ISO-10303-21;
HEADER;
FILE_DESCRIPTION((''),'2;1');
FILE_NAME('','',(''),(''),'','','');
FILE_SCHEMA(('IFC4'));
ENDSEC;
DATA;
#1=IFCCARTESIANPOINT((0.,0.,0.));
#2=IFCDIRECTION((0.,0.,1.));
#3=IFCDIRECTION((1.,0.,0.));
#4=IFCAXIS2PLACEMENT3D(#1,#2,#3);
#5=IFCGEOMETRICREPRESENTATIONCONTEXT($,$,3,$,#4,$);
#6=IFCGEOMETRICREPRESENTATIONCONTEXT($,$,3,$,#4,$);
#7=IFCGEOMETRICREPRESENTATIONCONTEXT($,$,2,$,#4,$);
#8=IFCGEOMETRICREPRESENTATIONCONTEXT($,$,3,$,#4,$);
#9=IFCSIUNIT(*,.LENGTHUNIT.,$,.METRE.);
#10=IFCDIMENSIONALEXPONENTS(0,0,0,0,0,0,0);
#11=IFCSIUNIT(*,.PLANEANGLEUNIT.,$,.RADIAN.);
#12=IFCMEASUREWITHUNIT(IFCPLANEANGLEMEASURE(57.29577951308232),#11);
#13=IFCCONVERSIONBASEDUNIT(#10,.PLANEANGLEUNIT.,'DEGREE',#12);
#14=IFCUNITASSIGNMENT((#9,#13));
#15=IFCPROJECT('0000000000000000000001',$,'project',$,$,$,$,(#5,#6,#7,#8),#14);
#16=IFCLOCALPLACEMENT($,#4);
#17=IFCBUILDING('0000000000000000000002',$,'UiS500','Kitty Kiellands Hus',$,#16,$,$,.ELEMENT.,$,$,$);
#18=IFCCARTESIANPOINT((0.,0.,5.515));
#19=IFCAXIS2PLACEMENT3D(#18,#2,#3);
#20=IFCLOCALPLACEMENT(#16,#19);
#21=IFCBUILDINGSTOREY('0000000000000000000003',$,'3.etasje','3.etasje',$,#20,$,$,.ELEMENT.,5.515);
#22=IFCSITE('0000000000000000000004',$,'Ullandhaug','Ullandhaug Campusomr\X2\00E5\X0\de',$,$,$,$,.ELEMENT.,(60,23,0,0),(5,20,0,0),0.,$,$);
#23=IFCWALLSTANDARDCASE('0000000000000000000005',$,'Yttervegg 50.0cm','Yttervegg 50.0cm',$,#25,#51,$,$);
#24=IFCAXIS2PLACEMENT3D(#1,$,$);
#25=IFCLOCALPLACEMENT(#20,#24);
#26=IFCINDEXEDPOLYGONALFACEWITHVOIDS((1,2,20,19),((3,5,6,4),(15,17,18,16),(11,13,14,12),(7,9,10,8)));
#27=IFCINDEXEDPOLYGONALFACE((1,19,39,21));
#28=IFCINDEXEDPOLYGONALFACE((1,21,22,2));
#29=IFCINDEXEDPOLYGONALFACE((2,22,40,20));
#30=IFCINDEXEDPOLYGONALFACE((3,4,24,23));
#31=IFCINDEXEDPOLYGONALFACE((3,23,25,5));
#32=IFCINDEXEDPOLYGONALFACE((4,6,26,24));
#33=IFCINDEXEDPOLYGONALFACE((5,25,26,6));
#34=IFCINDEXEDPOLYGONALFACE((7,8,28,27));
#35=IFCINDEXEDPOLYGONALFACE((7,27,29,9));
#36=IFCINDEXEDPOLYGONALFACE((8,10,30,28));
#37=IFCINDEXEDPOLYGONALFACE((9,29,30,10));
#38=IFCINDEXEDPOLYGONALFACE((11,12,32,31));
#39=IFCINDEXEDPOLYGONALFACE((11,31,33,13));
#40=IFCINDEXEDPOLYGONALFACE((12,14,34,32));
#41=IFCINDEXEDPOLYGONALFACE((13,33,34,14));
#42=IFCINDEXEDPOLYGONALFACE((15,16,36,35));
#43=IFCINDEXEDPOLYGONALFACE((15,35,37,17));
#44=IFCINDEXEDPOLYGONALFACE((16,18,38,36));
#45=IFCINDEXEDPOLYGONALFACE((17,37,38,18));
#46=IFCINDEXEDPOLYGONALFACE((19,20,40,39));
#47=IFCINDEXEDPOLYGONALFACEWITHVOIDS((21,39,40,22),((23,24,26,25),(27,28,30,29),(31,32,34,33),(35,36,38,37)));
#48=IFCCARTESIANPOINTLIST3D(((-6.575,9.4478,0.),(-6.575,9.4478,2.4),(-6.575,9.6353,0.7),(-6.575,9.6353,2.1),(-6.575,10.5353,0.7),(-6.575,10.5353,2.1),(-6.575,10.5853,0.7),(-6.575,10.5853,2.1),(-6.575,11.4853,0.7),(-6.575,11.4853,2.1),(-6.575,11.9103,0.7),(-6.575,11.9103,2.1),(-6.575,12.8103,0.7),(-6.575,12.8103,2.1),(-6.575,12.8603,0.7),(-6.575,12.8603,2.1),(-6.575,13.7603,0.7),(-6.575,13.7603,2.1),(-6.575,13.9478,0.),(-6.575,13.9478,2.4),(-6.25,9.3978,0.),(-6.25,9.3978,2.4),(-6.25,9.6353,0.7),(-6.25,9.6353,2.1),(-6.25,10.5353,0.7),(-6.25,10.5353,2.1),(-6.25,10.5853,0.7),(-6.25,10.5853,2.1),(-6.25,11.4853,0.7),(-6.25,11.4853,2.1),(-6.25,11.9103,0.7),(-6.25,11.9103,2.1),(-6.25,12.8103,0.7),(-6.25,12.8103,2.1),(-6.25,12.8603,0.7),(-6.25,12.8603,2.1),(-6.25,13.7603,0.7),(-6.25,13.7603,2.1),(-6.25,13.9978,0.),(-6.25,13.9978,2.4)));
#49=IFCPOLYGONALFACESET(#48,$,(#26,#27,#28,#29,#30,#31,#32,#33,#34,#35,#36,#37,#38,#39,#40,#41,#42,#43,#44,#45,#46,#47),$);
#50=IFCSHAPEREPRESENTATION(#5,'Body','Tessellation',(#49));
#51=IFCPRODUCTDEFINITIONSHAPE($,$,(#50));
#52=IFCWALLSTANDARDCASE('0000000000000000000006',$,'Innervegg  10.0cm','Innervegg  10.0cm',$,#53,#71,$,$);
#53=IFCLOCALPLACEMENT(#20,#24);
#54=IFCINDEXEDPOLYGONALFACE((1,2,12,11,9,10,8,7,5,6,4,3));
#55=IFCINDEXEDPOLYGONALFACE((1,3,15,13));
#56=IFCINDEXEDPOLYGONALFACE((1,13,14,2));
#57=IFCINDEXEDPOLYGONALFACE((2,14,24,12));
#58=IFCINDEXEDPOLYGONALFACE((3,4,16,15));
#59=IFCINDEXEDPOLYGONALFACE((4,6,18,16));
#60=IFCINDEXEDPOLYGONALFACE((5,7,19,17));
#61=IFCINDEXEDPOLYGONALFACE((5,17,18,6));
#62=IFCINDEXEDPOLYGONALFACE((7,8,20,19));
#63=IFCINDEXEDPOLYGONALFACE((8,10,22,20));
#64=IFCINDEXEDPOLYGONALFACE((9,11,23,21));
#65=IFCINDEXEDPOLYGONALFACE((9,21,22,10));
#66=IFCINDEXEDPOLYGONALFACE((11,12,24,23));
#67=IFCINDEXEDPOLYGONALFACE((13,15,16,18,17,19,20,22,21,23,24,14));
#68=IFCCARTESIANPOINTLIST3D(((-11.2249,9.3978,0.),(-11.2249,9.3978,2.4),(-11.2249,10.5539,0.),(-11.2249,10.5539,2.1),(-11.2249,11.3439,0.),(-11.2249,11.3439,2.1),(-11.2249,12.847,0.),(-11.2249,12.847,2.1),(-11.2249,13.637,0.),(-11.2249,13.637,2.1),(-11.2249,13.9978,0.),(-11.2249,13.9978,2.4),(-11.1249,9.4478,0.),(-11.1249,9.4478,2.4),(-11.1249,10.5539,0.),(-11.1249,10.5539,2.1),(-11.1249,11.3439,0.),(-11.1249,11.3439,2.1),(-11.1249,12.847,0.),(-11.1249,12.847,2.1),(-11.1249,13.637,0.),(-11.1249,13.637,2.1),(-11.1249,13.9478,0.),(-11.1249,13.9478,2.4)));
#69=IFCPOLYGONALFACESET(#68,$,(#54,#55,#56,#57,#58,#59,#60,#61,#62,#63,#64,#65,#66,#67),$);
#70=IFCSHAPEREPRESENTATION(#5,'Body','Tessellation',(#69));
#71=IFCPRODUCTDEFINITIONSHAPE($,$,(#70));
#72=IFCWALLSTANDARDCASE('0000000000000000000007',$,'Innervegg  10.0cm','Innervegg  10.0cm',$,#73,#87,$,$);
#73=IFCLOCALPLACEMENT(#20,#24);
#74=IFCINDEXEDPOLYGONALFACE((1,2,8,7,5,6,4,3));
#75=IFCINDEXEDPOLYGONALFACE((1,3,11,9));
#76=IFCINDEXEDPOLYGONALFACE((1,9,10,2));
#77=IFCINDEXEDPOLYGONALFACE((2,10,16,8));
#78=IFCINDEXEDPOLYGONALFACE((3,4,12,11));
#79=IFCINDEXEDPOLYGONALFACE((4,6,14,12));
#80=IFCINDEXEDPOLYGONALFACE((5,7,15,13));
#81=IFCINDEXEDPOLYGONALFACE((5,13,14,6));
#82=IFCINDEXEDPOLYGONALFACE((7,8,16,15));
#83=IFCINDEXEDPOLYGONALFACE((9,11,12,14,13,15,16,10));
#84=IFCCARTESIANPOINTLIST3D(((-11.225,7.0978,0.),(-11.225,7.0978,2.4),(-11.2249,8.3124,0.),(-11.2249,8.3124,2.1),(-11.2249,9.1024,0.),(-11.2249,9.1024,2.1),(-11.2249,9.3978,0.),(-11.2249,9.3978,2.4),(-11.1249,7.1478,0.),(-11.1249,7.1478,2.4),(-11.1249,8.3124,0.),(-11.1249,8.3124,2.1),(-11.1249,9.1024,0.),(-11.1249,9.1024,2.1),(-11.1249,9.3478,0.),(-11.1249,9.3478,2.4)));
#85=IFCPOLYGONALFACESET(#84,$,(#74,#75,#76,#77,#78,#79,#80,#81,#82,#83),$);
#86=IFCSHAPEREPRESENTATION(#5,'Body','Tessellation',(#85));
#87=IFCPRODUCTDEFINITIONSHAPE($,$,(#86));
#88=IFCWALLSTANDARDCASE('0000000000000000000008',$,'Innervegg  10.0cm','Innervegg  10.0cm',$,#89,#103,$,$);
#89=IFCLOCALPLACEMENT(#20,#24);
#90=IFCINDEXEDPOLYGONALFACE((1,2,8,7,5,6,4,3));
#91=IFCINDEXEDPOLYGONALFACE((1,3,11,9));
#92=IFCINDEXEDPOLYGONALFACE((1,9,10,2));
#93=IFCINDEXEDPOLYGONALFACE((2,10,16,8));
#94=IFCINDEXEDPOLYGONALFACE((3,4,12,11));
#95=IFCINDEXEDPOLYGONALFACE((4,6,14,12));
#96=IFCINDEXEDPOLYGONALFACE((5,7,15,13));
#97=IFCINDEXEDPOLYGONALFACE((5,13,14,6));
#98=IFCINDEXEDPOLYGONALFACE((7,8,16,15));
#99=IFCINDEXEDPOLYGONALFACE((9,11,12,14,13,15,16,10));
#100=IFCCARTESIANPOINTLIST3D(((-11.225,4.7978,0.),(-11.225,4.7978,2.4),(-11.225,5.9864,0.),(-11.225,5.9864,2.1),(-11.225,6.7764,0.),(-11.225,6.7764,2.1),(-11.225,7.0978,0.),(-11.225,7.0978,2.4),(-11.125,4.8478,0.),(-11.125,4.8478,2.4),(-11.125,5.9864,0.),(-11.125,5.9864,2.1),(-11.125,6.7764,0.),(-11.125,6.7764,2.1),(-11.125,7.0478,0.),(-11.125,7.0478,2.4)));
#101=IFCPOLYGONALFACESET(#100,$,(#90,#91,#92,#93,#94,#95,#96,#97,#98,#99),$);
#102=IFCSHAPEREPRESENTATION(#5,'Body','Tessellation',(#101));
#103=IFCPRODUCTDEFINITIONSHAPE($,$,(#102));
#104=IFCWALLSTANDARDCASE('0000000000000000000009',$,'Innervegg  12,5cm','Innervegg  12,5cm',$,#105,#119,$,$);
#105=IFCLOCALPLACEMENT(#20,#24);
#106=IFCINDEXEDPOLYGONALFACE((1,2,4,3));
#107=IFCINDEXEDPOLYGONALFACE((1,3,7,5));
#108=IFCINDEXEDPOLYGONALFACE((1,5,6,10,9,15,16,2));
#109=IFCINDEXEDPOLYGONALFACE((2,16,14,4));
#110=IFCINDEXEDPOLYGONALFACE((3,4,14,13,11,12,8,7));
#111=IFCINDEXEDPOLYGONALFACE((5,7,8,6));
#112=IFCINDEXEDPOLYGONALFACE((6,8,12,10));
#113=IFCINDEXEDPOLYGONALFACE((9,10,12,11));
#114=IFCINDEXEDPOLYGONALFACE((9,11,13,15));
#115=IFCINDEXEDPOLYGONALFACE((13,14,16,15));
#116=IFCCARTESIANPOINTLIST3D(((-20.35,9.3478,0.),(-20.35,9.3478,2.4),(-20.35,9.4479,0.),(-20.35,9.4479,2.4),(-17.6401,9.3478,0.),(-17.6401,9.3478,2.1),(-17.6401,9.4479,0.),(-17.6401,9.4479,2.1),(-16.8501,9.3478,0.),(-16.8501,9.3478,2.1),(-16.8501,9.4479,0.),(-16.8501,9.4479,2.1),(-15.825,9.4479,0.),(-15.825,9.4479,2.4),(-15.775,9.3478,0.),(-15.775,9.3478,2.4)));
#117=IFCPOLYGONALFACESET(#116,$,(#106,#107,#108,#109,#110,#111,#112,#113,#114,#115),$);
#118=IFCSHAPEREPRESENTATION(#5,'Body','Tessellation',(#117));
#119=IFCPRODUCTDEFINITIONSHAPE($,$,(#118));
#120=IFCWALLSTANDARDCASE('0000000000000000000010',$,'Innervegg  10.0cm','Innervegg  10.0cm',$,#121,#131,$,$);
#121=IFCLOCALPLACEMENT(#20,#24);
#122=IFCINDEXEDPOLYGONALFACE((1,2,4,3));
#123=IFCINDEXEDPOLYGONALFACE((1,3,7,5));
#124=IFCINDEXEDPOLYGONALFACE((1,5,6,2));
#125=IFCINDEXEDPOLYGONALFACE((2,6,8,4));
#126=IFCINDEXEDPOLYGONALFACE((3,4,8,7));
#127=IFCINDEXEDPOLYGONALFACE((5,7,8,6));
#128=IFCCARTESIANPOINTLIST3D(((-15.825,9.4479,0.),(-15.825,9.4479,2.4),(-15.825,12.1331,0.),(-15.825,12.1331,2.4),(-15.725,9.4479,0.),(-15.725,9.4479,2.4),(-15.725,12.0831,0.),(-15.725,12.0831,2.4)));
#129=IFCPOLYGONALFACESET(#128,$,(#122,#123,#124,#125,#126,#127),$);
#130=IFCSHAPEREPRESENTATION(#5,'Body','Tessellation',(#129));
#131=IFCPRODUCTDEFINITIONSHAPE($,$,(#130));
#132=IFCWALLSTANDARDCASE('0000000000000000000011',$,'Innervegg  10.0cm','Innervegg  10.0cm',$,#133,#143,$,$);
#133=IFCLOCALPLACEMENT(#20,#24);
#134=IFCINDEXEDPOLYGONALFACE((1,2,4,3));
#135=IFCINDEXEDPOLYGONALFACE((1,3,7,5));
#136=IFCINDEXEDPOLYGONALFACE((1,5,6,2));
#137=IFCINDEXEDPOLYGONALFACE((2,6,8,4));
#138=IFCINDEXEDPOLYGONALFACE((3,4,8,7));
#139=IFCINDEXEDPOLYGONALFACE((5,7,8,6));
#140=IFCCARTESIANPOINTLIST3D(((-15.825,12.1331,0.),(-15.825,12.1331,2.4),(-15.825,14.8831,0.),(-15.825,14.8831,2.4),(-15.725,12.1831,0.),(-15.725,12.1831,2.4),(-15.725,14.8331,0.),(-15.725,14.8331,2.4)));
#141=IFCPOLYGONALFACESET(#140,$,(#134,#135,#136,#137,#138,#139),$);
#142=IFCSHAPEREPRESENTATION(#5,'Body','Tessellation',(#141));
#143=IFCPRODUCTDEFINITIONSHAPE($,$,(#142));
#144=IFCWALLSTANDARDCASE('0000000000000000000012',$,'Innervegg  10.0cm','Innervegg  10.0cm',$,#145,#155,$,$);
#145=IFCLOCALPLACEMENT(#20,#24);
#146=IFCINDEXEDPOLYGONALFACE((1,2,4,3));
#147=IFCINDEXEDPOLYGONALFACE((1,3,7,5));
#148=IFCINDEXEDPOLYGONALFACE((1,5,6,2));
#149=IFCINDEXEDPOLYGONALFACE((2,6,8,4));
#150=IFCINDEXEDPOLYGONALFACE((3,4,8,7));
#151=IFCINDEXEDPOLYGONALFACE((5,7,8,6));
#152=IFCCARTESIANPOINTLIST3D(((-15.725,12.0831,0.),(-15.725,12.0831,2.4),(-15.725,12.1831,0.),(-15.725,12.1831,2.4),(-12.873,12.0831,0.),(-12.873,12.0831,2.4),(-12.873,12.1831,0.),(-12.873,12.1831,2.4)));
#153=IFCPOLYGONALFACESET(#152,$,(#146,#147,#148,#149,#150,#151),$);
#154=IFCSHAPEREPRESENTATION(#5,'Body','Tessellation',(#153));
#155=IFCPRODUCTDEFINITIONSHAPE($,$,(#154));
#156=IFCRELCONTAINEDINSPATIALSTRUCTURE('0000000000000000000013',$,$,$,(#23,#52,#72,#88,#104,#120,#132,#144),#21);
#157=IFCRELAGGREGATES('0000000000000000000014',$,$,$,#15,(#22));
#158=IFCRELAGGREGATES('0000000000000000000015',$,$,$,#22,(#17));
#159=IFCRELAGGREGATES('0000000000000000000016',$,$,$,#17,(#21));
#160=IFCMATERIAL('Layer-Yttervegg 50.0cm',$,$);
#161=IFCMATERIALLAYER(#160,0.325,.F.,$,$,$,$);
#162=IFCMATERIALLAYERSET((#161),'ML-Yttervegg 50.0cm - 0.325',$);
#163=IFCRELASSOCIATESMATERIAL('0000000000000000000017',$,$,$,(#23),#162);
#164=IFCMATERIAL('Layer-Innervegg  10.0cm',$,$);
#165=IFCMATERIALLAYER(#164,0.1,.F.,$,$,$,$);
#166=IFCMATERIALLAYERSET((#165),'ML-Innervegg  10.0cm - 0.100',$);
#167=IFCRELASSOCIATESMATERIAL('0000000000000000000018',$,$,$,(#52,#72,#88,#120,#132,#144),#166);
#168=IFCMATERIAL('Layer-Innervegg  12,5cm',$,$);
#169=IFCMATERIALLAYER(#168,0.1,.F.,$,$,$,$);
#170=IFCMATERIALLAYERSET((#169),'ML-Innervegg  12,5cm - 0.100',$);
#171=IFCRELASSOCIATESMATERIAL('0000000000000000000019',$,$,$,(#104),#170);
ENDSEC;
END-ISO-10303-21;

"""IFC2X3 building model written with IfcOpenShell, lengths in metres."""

from ifc_helpers import new_model, entity, si_unit, converted_unit, frame, origin_with_axes, place, context, project, spatial, polyline, outline, extrude, material, layer, layer_set, layer_usage, element, save


model = new_model("IFC2X3")

# Units and contexts
context_of_model_1 = context(None, 3, world=origin_with_axes())
context_of_model_2 = context(None, 3, world=origin_with_axes())
context_of_model_3 = context(None, 2, world=origin_with_axes())
context_of_model_4 = context(None, 3, world=origin_with_axes())
ifc_project = project(units=[si_unit("LENGTHUNIT", "METRE"), converted_unit("PLANEANGLEUNIT", "DEGREE", entity("IfcPlaneAngleMeasure", 57.29577951308232), si_unit("PLANEANGLEUNIT", "RADIAN"), dimensions=[0, 0, 0, 0, 0, 0, 0])], contexts=[context_of_model_1, context_of_model_2, context_of_model_3, context_of_model_4])

# Site, building, storey
site = spatial("IfcSite", under=ifc_project, Name="Ullandhaug", Description="Ullandhaug Campusområde", CompositionType="ELEMENT", RefLatitude=(60, 23, 0, 0), RefLongitude=(5, 20, 0, 0), RefElevation=0.0)
building_placement = place(None, origin_with_axes())
building = spatial("IfcBuilding", under=site, at=building_placement, Name="UiS500", Description="Kitty Kiellands Hus", CompositionType="ELEMENT")
storey_placement = place(building_placement, frame((0.0, 0.0, 5.515), z_axis=(0.0, 0.0, 1.0), x_axis=(1.0, 0.0, 0.0)))
storey = spatial("IfcBuildingStorey", under=building, at=storey_placement, Name="3.etasje", Description="3.etasje", CompositionType="ELEMENT", Elevation=5.515)

# Shared definitions
ifc_material_1 = material(Name="Layer-Innervegg  10.0cm")
ifc_layer_1 = layer(ifc_material_1, 0.1, ventilated=False)
ifc_layer_set_1 = layer_set([ifc_layer_1], Name="ML-Innervegg  10.0cm - 0.100")
ifc_layer_usage_1 = layer_usage(ifc_layer_set_1, "AXIS2", "POSITIVE", 0.0)

# Shared definitions
ifc_material_2 = material(Name="Layer-Yttervegg 50.0cm")
ifc_layer_2 = layer(ifc_material_2, 0.325, ventilated=False)
ifc_layer_set_2 = layer_set([ifc_layer_2], Name="ML-Yttervegg 50.0cm - 0.325")
ifc_layer_usage_2 = layer_usage(ifc_layer_set_2, "AXIS2", "POSITIVE", 0.0)

# Walls, openings
wall_1_placement = place(storey_placement, frame((-6.25, 9.3978, 0.0), z_axis=(0.0, 0.0, 1.0), x_axis=(0.0, 1.0, 0.0)))
wall_1 = element("IfcWallStandardCase", 1, at=wall_1_placement, inside=storey, material=ifc_layer_usage_2, Name="Yttervegg 50.0cm", Description="Yttervegg 50.0cm", context=context_of_model_1, shape_type="SweptSolid", body=[
    extrude(outline(polyline([(0.0, 0.0), (4.6, 0.0), (4.55, 0.325), (0.05, 0.325), (0.0, 0.0)])), frame((0.0, 0.0, 0.0), z_axis=(0.0, 0.0, 1.0), x_axis=(1.0, 0.0, 0.0)), (0.0, 0.0, 1.0), 2.4),
])
opening_1_placement = place(wall_1_placement, frame((0.2375, 0.325, 0.7), z_axis=(0.0, 0.0, 1.0), x_axis=(1.0, 0.0, 0.0)))
element("IfcOpeningElement", 2, at=opening_1_placement, cuts=wall_1, context=context_of_model_1, shape_type="SweptSolid", body=[
    extrude(outline(polyline([(0.0, 0.0), (1.4, 0.0), (1.4, 0.9), (0.0, 0.9), (0.0, 0.0)])), frame((0.0, 0.0, 0.0), z_axis=(0.0, 1.0, 0.0), x_axis=(0.0, 0.0, 1.0)), (0.0, 0.0, -1.0), 0.325),
])
opening_2_placement = place(wall_1_placement, frame((1.1875, 0.325, 0.7), z_axis=(0.0, 0.0, 1.0), x_axis=(1.0, 0.0, 0.0)))
element("IfcOpeningElement", 3, at=opening_2_placement, cuts=wall_1, context=context_of_model_1, shape_type="SweptSolid", body=[
    extrude(outline(polyline([(0.0, 0.0), (1.4, 0.0), (1.4, 0.9), (0.0, 0.9), (0.0, 0.0)])), frame((0.0, 0.0, 0.0), z_axis=(0.0, 1.0, 0.0), x_axis=(0.0, 0.0, 1.0)), (0.0, 0.0, -1.0), 0.325),
])
opening_3_placement = place(wall_1_placement, frame((2.5125, 0.325, 0.7), z_axis=(0.0, 0.0, 1.0), x_axis=(1.0, 0.0, 0.0)))
element("IfcOpeningElement", 4, at=opening_3_placement, cuts=wall_1, context=context_of_model_1, shape_type="SweptSolid", body=[
    extrude(outline(polyline([(0.0, 0.0), (1.4, 0.0), (1.4, 0.9), (0.0, 0.9), (0.0, 0.0)])), frame((0.0, 0.0, 0.0), z_axis=(0.0, 1.0, 0.0), x_axis=(0.0, 0.0, 1.0)), (0.0, 0.0, -1.0), 0.325),
])
opening_4_placement = place(wall_1_placement, frame((3.4625, 0.325, 0.7), z_axis=(0.0, 0.0, 1.0), x_axis=(1.0, 0.0, 0.0)))
element("IfcOpeningElement", 5, at=opening_4_placement, cuts=wall_1, context=context_of_model_1, shape_type="SweptSolid", body=[
    extrude(outline(polyline([(0.0, 0.0), (1.4, 0.0), (1.4, 0.9), (0.0, 0.9), (0.0, 0.0)])), frame((0.0, 0.0, 0.0), z_axis=(0.0, 1.0, 0.0), x_axis=(0.0, 0.0, 1.0)), (0.0, 0.0, -1.0), 0.325),
])
wall_2_placement = place(storey_placement, frame((-11.2249, 13.9978, 0.0), z_axis=(0.0, 0.0, 1.0), x_axis=(-0.00001, -1.0, 0.0)))
wall_2 = element("IfcWallStandardCase", 6, at=wall_2_placement, inside=storey, material=ifc_layer_usage_1, Name="Innervegg  10.0cm", Description="Innervegg  10.0cm", context=context_of_model_1, shape_type="SweptSolid", body=[
    extrude(outline(polyline([(0.0, 0.0), (4.6, 0.0), (4.55, 0.1), (0.05, 0.1), (0.0, 0.0)])), frame((0.0, 0.0, 0.0), z_axis=(0.0, 0.0, 1.0), x_axis=(1.0, 0.0, 0.0)), (0.0, 0.0, 1.0), 2.4),
])
opening_5_placement = place(wall_2_placement, frame((2.6539, 0.1, 0.0), z_axis=(0.0, 0.0, 1.0), x_axis=(1.0, 0.0, 0.0)))
element("IfcOpeningElement", 7, at=opening_5_placement, cuts=wall_2, context=context_of_model_1, shape_type="SweptSolid", body=[
    extrude(outline(polyline([(0.0, 0.0), (2.1, 0.0), (2.1, 0.79), (0.0, 0.79), (0.0, 0.0)])), frame((0.0, 0.0, 0.0), z_axis=(-0.00001, 1.0, 0.0), x_axis=(0.0, 0.0, 1.0)), (0.0, -0.00001, -1.0), 0.1),
])
opening_6_placement = place(wall_2_placement, frame((0.3607, 0.1, 0.0), z_axis=(0.0, 0.0, 1.0), x_axis=(1.0, 0.0, 0.0)))
element("IfcOpeningElement", 8, at=opening_6_placement, cuts=wall_2, context=context_of_model_1, shape_type="SweptSolid", body=[
    extrude(outline(polyline([(0.0, 0.0), (2.1, 0.0), (2.1, 0.79), (0.0, 0.79), (0.0, 0.0)])), frame((0.0, 0.0, 0.0), z_axis=(-0.00001, 1.0, 0.0), x_axis=(0.0, 0.0, 1.0)), (0.0, -0.00001, -1.0), 0.1),
])

# Walls, openings
wall_3_placement = place(storey_placement, frame((-11.2249, 9.3978, 0.0), z_axis=(0.0, 0.0, 1.0), x_axis=(-0.000009, -1.0, 0.0)))
wall_3 = element("IfcWallStandardCase", 9, at=wall_3_placement, inside=storey, material=ifc_layer_usage_1, Name="Innervegg  10.0cm", Description="Innervegg  10.0cm", context=context_of_model_1, shape_type="SweptSolid", body=[
    extrude(outline(polyline([(0.0, 0.0), (2.3, 0.0), (2.25, 0.1), (0.05, 0.1), (0.0, 0.0)])), frame((0.0, 0.0, 0.0), z_axis=(0.0, 0.0, 1.0), x_axis=(1.0, 0.0, 0.0)), (0.0, 0.0, 1.0), 2.4),
])
opening_7_placement = place(wall_3_placement, frame((0.2954, 0.1, 0.0), z_axis=(0.0, 0.0, 1.0), x_axis=(1.0, 0.0, 0.0)))
element("IfcOpeningElement", 10, at=opening_7_placement, cuts=wall_3, context=context_of_model_1, shape_type="SweptSolid", body=[
    extrude(outline(polyline([(0.0, 0.0), (2.1, 0.0), (2.1, 0.79), (0.0, 0.79), (0.0, 0.0)])), frame((0.0, 0.0, 0.0), z_axis=(-0.000009, 1.0, 0.0), x_axis=(0.0, 0.0, 1.0)), (0.0, -0.000009, -1.0), 0.1),
])
wall_4_placement = place(storey_placement, frame((-11.225, 7.0978, 0.0), z_axis=(0.0, 0.0, 1.0), x_axis=(-0.000009, -1.0, 0.0)))
wall_4 = element("IfcWallStandardCase", 11, at=wall_4_placement, inside=storey, material=ifc_layer_usage_1, Name="Innervegg  10.0cm", Description="Innervegg  10.0cm", context=context_of_model_1, shape_type="SweptSolid", body=[
    extrude(outline(polyline([(0.0, 0.0), (2.3, 0.0), (2.25, 0.1), (0.05, 0.1), (0.0, 0.0)])), frame((0.0, 0.0, 0.0), z_axis=(0.0, 0.0, 1.0), x_axis=(1.0, 0.0, 0.0)), (0.0, 0.0, 1.0), 2.4),
])
opening_8_placement = place(wall_4_placement, frame((0.3213, 0.1, 0.0), z_axis=(0.0, 0.0, 1.0), x_axis=(1.0, 0.0, 0.0)))
element("IfcOpeningElement", 12, at=opening_8_placement, cuts=wall_4, context=context_of_model_1, shape_type="SweptSolid", body=[
    extrude(outline(polyline([(0.0, 0.0), (2.1, 0.0), (2.1, 0.79), (0.0, 0.79), (0.0, 0.0)])), frame((0.0, 0.0, 0.0), z_axis=(-0.000009, 1.0, 0.0), x_axis=(0.0, 0.0, 1.0)), (0.0, -0.000009, -1.0), 0.1),
])
ifc_material_3 = material(Name="Layer-Innervegg  12,5cm")
ifc_layer_3 = layer(ifc_material_3, 0.1, ventilated=False)
ifc_layer_set_3 = layer_set([ifc_layer_3], Name="ML-Innervegg  12,5cm - 0.100")
ifc_layer_usage_3 = layer_usage(ifc_layer_set_3, "AXIS2", "POSITIVE", 0.0)
wall_5_placement = place(storey_placement, frame((-20.35, 9.3478, 0.0), z_axis=(0.0, 0.0, 1.0), x_axis=(1.0, 0.0, 0.0)))
wall_5 = element("IfcWallStandardCase", 13, at=wall_5_placement, inside=storey, material=ifc_layer_usage_3, Name="Innervegg  12,5cm", Description="Innervegg  12,5cm", context=context_of_model_1, shape_type="SweptSolid", body=[
    extrude(outline(polyline([(0.0, 0.0), (4.575, 0.0), (4.525, 0.1002), (0.0, 0.1002), (0.0, 0.0)])), origin_with_axes(), (0.0, 0.0, 1.0), 2.4),
])
opening_9_placement = place(wall_5_placement, frame((2.7099, 0.1002, 0.0), z_axis=(0.0, 0.0, 1.0), x_axis=(1.0, 0.0, 0.0)))
element("IfcOpeningElement", 14, at=opening_9_placement, cuts=wall_5, context=context_of_model_1, shape_type="SweptSolid", body=[
    extrude(outline(polyline([(0.0, 0.0), (2.1, 0.0), (2.1, 0.79), (0.0, 0.79), (0.0, 0.0)])), frame((0.0, 0.0, 0.0), z_axis=(0.0, 1.0, 0.0), x_axis=(0.0, 0.0, 1.0)), (0.0, 0.0, -1.0), 0.1002),
])

# Walls
wall_6_placement = place(storey_placement, frame((-15.725, 9.4479, 0.0), z_axis=(0.0, 0.0, 1.0), x_axis=(0.0, 1.0, 0.0)))
element("IfcWallStandardCase", 15, at=wall_6_placement, inside=storey, material=ifc_layer_usage_1, Name="Innervegg  10.0cm", Description="Innervegg  10.0cm", context=context_of_model_1, shape_type="SweptSolid", body=[
    extrude(outline(polyline([(0.0, 0.0), (2.6351, 0.0), (2.6851, 0.1), (0.0, 0.1), (0.0, 0.0)])), frame((0.0, 0.0, 0.0), z_axis=(0.0, 0.0, 1.0), x_axis=(1.0, 0.0, 0.0)), (0.0, 0.0, 1.0), 2.4),
])
wall_7_placement = place(storey_placement, frame((-15.725, 12.1831, 0.0), z_axis=(0.0, 0.0, 1.0), x_axis=(0.0, 1.0, 0.0)))
element("IfcWallStandardCase", 16, at=wall_7_placement, inside=storey, material=ifc_layer_usage_1, Name="Innervegg  10.0cm", Description="Innervegg  10.0cm", context=context_of_model_1, shape_type="SweptSolid", body=[
    extrude(outline(polyline([(0.0, 0.0), (2.65, 0.0), (2.7, 0.1), (-0.05, 0.1), (0.0, 0.0)])), frame((0.0, 0.0, 0.0), z_axis=(0.0, 0.0, 1.0), x_axis=(1.0, 0.0, 0.0)), (0.0, 0.0, 1.0), 2.4),
])
wall_8_placement = place(storey_placement, frame((-15.725, 12.0831, 0.0), z_axis=(0.0, 0.0, 1.0), x_axis=(1.0, 0.0, 0.0)))
element("IfcWallStandardCase", 17, at=wall_8_placement, inside=storey, material=ifc_layer_usage_1, Name="Innervegg  10.0cm", Description="Innervegg  10.0cm", context=context_of_model_1, shape_type="SweptSolid", body=[
    extrude(outline(polyline([(0.0, 0.0), (2.852, 0.0), (2.852, 0.1), (0.0, 0.1), (0.0, 0.0)])), origin_with_axes(), (0.0, 0.0, 1.0), 2.4),
])

save(model, "model.ifc")
